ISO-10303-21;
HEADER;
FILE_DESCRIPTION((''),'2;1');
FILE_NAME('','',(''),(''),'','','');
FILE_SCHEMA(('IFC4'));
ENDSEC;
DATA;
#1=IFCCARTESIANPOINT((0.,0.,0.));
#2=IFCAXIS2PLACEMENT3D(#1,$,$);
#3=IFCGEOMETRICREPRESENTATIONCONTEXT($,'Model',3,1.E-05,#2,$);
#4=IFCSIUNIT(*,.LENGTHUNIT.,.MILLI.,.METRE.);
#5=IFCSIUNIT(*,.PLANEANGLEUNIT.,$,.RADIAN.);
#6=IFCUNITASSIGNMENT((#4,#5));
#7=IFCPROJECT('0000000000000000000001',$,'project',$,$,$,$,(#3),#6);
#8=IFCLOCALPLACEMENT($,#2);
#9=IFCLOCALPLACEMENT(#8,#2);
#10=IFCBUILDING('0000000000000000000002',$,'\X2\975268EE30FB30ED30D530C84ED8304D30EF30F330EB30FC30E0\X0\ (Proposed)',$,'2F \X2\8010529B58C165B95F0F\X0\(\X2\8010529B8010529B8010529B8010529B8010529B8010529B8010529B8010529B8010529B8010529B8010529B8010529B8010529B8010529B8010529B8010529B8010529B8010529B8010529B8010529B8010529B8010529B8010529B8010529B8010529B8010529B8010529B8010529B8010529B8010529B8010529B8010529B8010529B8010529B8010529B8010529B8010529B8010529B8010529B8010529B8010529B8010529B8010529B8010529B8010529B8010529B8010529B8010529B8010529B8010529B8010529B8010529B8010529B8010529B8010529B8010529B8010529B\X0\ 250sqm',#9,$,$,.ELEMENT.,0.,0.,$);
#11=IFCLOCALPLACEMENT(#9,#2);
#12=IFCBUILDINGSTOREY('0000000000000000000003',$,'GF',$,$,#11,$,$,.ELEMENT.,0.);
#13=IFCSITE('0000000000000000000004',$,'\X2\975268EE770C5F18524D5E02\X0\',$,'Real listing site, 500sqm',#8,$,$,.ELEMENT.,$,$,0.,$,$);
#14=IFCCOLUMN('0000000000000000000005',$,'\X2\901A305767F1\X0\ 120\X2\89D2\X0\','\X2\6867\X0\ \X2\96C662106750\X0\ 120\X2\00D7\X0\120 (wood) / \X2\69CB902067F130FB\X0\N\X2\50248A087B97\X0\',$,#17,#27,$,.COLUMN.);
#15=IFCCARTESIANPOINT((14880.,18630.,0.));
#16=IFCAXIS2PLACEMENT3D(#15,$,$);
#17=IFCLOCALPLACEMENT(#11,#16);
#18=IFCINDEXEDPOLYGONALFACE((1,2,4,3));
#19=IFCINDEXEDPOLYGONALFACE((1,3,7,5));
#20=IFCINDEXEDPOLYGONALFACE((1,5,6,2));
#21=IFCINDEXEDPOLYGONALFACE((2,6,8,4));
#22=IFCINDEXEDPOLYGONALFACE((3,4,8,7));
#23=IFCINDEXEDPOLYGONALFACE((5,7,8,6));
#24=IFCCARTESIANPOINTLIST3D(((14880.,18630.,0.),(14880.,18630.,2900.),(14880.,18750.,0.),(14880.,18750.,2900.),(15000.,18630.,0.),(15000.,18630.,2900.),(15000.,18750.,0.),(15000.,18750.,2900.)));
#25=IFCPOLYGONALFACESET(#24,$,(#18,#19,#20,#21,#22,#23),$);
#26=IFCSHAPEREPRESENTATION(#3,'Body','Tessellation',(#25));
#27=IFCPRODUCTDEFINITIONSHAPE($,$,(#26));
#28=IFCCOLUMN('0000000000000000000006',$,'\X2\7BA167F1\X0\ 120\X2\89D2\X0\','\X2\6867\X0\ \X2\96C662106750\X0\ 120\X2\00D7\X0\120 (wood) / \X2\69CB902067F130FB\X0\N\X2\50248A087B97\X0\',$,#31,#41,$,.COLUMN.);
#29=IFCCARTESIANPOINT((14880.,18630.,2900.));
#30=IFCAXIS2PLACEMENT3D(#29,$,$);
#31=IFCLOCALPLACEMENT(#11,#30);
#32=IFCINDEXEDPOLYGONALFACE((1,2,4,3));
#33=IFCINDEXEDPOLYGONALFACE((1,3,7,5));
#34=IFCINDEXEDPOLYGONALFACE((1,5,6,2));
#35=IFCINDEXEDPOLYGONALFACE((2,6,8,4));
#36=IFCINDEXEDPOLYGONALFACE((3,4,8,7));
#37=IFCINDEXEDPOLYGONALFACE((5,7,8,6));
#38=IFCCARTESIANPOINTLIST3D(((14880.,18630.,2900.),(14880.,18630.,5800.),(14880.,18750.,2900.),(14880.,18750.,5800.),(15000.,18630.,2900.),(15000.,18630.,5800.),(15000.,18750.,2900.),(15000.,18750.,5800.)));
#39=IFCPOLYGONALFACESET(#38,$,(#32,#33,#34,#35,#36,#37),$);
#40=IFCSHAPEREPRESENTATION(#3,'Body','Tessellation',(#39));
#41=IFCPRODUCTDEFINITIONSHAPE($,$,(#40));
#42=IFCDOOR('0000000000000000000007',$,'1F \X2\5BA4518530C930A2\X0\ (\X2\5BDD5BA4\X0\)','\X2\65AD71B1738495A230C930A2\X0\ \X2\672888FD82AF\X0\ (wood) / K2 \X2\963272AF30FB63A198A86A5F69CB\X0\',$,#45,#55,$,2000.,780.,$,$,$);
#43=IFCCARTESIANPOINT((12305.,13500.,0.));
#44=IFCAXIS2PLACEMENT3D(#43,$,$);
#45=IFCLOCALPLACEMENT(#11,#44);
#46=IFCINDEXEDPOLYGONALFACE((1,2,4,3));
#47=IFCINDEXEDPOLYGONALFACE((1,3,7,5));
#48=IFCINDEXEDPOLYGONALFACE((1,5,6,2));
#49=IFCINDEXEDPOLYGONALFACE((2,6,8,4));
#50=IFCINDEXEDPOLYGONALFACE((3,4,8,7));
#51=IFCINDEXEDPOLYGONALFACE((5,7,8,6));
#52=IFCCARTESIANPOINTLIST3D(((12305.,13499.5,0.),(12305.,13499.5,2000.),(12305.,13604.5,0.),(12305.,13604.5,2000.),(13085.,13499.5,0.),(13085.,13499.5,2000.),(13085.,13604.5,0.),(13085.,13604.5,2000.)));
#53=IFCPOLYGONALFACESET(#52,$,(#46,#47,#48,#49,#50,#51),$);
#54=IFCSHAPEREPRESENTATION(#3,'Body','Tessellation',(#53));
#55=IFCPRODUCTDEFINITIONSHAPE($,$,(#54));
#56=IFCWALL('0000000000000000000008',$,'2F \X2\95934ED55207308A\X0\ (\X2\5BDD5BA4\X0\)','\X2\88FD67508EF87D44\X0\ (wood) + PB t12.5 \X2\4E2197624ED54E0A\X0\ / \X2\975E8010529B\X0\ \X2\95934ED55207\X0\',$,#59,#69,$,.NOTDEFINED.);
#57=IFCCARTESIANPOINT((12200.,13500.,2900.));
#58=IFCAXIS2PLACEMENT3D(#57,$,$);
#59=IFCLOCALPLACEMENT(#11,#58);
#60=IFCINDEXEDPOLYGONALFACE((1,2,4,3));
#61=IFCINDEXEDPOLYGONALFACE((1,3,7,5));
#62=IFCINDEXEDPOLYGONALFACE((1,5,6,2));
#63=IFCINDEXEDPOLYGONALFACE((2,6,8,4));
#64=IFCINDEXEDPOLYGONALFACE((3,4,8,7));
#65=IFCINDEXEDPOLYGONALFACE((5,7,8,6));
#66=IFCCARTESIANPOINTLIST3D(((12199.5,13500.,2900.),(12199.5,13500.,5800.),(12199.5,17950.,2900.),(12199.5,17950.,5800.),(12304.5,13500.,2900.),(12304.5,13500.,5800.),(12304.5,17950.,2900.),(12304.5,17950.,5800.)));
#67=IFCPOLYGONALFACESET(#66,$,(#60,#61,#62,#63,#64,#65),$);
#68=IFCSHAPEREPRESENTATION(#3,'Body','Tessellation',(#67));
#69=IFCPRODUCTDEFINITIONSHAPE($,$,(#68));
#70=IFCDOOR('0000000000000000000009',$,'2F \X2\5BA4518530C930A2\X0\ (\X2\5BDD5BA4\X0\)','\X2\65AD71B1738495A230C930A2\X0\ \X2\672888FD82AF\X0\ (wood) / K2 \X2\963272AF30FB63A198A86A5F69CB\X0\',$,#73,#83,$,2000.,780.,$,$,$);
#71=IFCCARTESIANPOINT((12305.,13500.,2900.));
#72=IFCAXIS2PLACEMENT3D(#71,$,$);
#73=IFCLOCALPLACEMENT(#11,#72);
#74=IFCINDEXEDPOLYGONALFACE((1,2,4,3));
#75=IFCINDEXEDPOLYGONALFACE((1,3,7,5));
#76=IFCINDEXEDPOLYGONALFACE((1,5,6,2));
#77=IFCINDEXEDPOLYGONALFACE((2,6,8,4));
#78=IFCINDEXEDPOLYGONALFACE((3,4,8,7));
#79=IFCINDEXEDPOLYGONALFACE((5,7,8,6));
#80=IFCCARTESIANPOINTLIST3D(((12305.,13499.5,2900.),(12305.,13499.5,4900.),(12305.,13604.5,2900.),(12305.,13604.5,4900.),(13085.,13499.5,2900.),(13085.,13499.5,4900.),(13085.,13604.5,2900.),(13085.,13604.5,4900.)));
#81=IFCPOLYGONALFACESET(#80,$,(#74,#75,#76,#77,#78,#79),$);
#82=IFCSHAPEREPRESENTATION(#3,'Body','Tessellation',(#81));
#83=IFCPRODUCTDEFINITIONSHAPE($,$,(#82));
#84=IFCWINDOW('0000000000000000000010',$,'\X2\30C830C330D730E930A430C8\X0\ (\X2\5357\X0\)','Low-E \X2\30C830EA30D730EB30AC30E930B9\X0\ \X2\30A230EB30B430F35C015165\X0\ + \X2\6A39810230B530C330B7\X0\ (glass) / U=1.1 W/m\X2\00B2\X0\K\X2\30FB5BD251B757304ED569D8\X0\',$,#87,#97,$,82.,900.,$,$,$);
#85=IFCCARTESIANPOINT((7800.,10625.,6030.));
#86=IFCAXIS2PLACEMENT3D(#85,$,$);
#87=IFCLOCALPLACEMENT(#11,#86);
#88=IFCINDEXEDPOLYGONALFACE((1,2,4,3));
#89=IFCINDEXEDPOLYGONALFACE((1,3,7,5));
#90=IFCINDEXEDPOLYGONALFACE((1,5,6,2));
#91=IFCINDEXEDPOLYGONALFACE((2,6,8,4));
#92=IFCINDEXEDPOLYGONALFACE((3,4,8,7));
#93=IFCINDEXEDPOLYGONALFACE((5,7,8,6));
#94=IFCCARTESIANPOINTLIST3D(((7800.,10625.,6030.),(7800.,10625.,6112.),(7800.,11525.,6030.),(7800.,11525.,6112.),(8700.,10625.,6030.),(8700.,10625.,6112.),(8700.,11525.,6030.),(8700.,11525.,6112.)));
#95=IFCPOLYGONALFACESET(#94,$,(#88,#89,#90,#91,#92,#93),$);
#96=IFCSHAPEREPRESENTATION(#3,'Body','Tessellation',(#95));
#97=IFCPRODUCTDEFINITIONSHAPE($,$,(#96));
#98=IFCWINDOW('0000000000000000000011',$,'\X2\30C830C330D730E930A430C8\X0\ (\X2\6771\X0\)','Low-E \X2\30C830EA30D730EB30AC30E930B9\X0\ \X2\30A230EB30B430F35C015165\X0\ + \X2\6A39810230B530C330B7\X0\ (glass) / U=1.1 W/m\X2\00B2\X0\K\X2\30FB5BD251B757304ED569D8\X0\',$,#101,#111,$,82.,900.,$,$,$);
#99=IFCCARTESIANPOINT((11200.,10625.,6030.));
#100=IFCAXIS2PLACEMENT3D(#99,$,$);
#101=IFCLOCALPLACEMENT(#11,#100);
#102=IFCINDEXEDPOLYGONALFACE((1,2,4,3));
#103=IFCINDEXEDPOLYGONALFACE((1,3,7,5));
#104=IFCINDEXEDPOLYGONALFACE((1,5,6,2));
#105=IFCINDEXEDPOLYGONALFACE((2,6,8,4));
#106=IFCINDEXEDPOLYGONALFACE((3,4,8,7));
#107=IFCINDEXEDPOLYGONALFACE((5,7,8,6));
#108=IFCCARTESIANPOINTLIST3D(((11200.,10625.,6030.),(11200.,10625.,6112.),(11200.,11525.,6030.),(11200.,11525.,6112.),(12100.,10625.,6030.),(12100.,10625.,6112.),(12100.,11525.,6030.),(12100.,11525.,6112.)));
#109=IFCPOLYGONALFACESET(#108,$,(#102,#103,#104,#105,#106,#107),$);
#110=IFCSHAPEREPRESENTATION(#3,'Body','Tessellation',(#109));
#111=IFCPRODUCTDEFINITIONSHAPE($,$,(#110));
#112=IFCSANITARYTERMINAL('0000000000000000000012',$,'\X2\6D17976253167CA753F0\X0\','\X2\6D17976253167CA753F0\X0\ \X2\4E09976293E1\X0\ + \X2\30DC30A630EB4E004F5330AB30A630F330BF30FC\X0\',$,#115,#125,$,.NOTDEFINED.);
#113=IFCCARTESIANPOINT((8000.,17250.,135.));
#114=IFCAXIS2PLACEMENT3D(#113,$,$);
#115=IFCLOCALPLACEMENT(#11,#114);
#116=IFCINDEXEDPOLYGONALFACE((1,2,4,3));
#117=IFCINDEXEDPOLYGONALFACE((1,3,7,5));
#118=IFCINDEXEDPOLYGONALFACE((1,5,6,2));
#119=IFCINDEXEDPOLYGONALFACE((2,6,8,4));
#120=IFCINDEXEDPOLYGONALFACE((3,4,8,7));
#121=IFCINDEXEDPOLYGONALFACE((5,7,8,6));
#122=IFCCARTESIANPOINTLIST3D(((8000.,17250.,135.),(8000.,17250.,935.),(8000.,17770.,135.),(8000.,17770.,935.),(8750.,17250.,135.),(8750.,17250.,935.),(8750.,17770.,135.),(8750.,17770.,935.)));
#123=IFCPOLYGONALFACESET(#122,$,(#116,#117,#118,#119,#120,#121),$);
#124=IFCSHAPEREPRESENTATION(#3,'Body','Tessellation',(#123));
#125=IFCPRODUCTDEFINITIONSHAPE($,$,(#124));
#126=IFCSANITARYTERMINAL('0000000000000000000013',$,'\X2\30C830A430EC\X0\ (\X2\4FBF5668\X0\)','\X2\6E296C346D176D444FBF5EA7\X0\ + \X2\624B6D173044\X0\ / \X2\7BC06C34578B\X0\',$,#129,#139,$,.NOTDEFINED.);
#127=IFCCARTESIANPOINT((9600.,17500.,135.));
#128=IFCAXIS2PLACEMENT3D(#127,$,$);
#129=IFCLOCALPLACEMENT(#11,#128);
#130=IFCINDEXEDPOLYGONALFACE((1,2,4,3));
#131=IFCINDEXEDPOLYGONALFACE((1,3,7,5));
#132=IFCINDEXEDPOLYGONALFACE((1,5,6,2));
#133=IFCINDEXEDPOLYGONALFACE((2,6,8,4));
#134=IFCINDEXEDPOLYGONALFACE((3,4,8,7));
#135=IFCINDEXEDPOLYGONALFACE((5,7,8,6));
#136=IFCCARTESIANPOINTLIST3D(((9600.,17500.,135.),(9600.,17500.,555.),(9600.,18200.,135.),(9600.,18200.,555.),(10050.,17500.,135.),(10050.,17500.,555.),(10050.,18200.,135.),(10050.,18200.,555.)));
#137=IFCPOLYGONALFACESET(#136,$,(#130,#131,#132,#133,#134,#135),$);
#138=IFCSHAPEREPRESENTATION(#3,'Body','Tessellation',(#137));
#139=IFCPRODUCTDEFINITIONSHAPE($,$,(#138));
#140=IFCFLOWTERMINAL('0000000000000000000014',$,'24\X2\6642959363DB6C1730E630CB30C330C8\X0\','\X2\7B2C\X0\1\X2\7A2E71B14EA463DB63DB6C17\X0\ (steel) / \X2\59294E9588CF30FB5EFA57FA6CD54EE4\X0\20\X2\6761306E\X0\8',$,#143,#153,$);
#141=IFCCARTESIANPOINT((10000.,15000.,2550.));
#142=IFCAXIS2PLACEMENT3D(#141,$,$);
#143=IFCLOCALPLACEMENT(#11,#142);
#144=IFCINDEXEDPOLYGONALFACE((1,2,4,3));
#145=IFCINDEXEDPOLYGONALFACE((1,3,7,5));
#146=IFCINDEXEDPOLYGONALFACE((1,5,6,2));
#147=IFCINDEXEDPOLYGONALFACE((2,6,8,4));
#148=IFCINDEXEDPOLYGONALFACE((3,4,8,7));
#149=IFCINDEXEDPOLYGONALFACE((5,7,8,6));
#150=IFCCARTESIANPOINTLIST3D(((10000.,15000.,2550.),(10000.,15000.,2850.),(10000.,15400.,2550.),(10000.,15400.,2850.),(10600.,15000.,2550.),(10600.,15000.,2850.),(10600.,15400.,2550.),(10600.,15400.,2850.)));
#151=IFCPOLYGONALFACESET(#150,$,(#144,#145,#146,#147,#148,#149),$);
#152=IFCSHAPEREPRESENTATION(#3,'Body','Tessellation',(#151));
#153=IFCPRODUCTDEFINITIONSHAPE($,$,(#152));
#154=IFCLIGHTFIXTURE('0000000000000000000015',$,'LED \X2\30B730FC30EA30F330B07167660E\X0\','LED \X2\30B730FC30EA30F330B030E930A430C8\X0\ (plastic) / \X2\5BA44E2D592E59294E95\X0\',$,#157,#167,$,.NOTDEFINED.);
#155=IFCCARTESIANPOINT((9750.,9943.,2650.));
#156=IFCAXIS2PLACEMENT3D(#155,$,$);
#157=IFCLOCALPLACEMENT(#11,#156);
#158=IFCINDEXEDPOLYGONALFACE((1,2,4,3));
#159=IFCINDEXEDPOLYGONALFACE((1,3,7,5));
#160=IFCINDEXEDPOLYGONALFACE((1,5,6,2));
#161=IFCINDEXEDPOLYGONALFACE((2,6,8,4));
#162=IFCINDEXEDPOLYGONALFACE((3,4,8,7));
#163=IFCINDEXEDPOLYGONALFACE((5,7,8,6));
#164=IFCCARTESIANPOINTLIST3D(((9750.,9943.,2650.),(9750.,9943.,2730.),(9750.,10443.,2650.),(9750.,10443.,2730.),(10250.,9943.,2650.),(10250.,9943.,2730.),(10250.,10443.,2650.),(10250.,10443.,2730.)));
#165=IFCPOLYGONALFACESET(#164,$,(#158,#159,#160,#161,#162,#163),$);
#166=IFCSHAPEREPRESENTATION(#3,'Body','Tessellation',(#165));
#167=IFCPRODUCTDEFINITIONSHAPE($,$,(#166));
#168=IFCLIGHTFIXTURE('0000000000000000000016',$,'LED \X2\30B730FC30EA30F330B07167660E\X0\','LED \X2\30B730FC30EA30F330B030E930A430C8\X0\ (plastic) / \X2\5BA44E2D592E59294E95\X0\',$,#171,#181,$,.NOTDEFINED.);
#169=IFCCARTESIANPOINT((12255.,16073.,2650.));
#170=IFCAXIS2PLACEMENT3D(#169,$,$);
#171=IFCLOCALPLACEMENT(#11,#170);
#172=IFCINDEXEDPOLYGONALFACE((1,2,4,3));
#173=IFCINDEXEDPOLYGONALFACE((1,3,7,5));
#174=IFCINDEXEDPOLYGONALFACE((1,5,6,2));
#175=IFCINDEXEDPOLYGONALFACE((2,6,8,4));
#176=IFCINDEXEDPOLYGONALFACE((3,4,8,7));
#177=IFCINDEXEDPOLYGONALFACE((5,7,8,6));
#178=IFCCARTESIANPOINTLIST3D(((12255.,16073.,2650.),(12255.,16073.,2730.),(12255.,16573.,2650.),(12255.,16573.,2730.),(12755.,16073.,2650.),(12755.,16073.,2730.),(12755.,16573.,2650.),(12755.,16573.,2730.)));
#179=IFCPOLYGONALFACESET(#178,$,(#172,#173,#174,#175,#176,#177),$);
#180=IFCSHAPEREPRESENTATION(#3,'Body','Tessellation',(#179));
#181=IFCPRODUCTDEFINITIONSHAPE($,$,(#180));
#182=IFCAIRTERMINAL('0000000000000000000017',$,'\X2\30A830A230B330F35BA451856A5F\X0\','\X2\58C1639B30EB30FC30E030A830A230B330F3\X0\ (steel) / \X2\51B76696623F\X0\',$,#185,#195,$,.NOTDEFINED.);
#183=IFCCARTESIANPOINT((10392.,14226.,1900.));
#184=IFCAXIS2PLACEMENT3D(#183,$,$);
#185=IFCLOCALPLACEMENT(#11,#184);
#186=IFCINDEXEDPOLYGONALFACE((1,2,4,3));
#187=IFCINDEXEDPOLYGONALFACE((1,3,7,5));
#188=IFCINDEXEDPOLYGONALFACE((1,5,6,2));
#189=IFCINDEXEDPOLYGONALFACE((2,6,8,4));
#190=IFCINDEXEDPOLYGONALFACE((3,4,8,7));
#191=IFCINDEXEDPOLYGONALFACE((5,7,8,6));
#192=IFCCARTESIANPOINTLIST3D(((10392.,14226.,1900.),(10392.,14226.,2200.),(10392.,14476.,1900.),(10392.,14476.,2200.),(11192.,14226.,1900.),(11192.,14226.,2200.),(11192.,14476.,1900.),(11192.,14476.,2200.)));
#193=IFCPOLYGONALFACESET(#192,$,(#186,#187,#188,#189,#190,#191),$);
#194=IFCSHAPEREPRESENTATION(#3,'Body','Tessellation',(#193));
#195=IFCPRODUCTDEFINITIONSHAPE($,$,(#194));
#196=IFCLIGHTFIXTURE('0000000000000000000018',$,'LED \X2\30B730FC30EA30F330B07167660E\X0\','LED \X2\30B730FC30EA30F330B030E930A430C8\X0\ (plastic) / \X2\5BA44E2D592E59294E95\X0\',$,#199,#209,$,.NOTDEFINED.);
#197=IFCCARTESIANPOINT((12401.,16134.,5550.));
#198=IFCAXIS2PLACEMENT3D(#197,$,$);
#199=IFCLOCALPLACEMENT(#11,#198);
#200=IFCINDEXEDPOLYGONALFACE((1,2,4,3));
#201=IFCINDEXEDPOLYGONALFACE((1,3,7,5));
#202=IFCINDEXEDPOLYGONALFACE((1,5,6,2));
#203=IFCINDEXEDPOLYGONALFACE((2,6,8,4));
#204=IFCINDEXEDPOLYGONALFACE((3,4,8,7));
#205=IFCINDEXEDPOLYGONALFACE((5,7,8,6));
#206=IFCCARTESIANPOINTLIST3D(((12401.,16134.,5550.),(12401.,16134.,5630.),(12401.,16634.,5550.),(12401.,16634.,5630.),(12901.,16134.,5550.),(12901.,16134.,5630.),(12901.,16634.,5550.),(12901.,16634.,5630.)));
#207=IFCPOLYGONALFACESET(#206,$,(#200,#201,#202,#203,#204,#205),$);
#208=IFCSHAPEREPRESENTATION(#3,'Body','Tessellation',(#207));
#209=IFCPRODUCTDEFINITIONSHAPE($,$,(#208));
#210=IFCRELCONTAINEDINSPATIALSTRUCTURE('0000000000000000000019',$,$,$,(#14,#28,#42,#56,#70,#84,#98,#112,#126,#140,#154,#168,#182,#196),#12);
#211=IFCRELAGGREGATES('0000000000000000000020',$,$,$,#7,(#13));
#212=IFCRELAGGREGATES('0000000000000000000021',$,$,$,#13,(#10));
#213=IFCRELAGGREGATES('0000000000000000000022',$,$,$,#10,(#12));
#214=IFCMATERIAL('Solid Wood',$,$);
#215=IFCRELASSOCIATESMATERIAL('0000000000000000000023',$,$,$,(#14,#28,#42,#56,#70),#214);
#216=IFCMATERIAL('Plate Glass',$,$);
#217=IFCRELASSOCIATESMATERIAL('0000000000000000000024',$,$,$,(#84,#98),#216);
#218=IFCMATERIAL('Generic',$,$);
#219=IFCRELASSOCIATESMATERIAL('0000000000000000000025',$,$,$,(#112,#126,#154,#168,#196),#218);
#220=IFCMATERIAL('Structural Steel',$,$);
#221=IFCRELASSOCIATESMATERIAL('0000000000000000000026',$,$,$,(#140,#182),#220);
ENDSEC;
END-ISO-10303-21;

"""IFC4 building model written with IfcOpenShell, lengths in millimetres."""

from ifc_helpers import new_model, si_unit, frame, frame_2d, origin, place, context, project, spatial, rectangle, extrude, material, element, save


model = new_model("IFC4")

# Units and contexts
model_context = context("Model", 3, precision=1e-05, world=origin())
ifc_project = project(units=[si_unit("LENGTHUNIT", "METRE", prefix="MILLI"), si_unit("PLANEANGLEUNIT", "RADIAN")], contexts=[model_context])

# Site, building, storey
site_placement = place(None, origin())
site = spatial("IfcSite", under=ifc_project, at=site_placement, Name="青森県弘前市", ObjectType="Real listing site, 500sqm", CompositionType="ELEMENT", RefElevation=0.0)
building_placement = place(site_placement, origin())
building = spatial("IfcBuilding", under=site, at=building_placement, Name="青森・ロフト付きワンルーム (Proposed)", ObjectType="2F 耐力壁方式(耐力耐力耐力耐力耐力耐力耐力耐力耐力耐力耐力耐力耐力耐力耐力耐力耐力耐力耐力耐力耐力耐力耐力耐力耐力耐力耐力耐力耐力耐力耐力耐力耐力耐力耐力耐力耐力耐力耐力耐力耐力耐力耐力耐力耐力耐力耐力耐力耐力耐力耐力耐力耐力耐力耐力耐力耐力 250sqm", CompositionType="ELEMENT", ElevationOfRefHeight=0.0, ElevationOfTerrain=0.0)
storey_placement = place(building_placement, origin())
storey = spatial("IfcBuildingStorey", under=building, at=storey_placement, Name="GF", CompositionType="ELEMENT", Elevation=0.0)

# Columns
ifc_material_1 = material(Name="Solid Wood")
column_1_placement = place(storey_placement, frame((14880.0, 18630.0, 0.0)))
element("IfcColumn", 1, at=column_1_placement, inside=storey, material=ifc_material_1, Name="通し柱 120角", Description="桧 集成材 120×120 (wood) / 構造柱・N値計算", PredefinedType="COLUMN", context=model_context, shape_type="SweptSolid", body=[
    extrude(rectangle(XDim=120.0, YDim=120.0, at=frame_2d((60.0, 60.0))), frame((14880.0, 18630.0, 0.0)), (0.0, 0.0, 1.0), 2900.0),
])
column_2_placement = place(storey_placement, frame((14880.0, 18630.0, 2900.0)))
element("IfcColumn", 2, at=column_2_placement, inside=storey, material=ifc_material_1, Name="管柱 120角", Description="桧 集成材 120×120 (wood) / 構造柱・N値計算", PredefinedType="COLUMN", context=model_context, shape_type="SweptSolid", body=[
    extrude(rectangle(XDim=120.0, YDim=120.0, at=frame_2d((60.0, 60.0))), frame((14880.0, 18630.0, 2900.0)), (0.0, 0.0, 1.0), 2900.0),
])

# Door
door_1_placement = place(storey_placement, frame((12305.0, 13500.0, 0.0)))
element("IfcDoor", 3, at=door_1_placement, inside=storey, material=ifc_material_1, Name="1F 室内ドア (寝室)", Description="断熱玄関ドア 木製芯 (wood) / K2 防犯・採風機構", OverallHeight=2000.0, OverallWidth=780.0, context=model_context, shape_type="SweptSolid", body=[
    extrude(rectangle(XDim=780.0, YDim=105.0, at=frame_2d((390.0, 52.0))), frame((12305.0, 13500.0, 0.0)), (0.0, 0.0, 1.0), 2000.0),
])

# Wall
wall_1_placement = place(storey_placement, frame((12200.0, 13500.0, 2900.0)))
element("IfcWall", 4, at=wall_1_placement, inside=storey, material=ifc_material_1, Name="2F 間仕切り (寝室)", Description="製材軸組 (wood) + PB t12.5 両面仕上 / 非耐力 間仕切", PredefinedType="NOTDEFINED", context=model_context, shape_type="SweptSolid", body=[
    extrude(rectangle(XDim=105.0, YDim=4450.0, at=frame_2d((52.0, 2225.0))), frame((12200.0, 13500.0, 2900.0)), (0.0, 0.0, 1.0), 2900.0),
])

# Door
door_2_placement = place(storey_placement, frame((12305.0, 13500.0, 2900.0)))
element("IfcDoor", 5, at=door_2_placement, inside=storey, material=ifc_material_1, Name="2F 室内ドア (寝室)", Description="断熱玄関ドア 木製芯 (wood) / K2 防犯・採風機構", OverallHeight=2000.0, OverallWidth=780.0, context=model_context, shape_type="SweptSolid", body=[
    extrude(rectangle(XDim=780.0, YDim=105.0, at=frame_2d((390.0, 52.0))), frame((12305.0, 13500.0, 2900.0)), (0.0, 0.0, 1.0), 2000.0),
])

# Windows
ifc_material_2 = material(Name="Plate Glass")
window_1_placement = place(storey_placement, frame((7800.0, 10625.0, 6030.0)))
element("IfcWindow", 6, at=window_1_placement, inside=storey, material=ifc_material_2, Name="トップライト (南)", Description="Low-E トリプルガラス アルゴン封入 + 樹脂サッシ (glass) / U=1.1 W/m²K・寒冷地仕様", OverallHeight=82.0, OverallWidth=900.0, context=model_context, shape_type="SweptSolid", body=[
    extrude(rectangle(XDim=900.0, YDim=900.0, at=frame_2d((450.0, 450.0))), frame((7800.0, 10625.0, 6030.0)), (0.0, 0.0, 1.0), 82.0),
])
window_2_placement = place(storey_placement, frame((11200.0, 10625.0, 6030.0)))
element("IfcWindow", 7, at=window_2_placement, inside=storey, material=ifc_material_2, Name="トップライト (東)", Description="Low-E トリプルガラス アルゴン封入 + 樹脂サッシ (glass) / U=1.1 W/m²K・寒冷地仕様", OverallHeight=82.0, OverallWidth=900.0, context=model_context, shape_type="SweptSolid", body=[
    extrude(rectangle(XDim=900.0, YDim=900.0, at=frame_2d((450.0, 450.0))), frame((11200.0, 10625.0, 6030.0)), (0.0, 0.0, 1.0), 82.0),
])

# Sanitary terminals
ifc_material_3 = material(Name="Generic")
sanitary_terminal_1_placement = place(storey_placement, frame((8000.0, 17250.0, 135.0)))
element("IfcSanitaryTerminal", 8, at=sanitary_terminal_1_placement, inside=storey, material=ifc_material_3, Name="洗面化粧台", Description="洗面化粧台 三面鏡 + ボウル一体カウンター", PredefinedType="NOTDEFINED", context=model_context, shape_type="SweptSolid", body=[
    extrude(rectangle(XDim=750.0, YDim=520.0, at=frame_2d((375.0, 260.0))), frame((8000.0, 17250.0, 135.0)), (0.0, 0.0, 1.0), 800.0),
])
sanitary_terminal_2_placement = place(storey_placement, frame((9600.0, 17500.0, 135.0)))
element("IfcSanitaryTerminal", 9, at=sanitary_terminal_2_placement, inside=storey, material=ifc_material_3, Name="トイレ (便器)", Description="温水洗浄便座 + 手洗い / 節水型", PredefinedType="NOTDEFINED", context=model_context, shape_type="SweptSolid", body=[
    extrude(rectangle(XDim=450.0, YDim=700.0, at=frame_2d((225.0, 350.0))), frame((9600.0, 17500.0, 135.0)), (0.0, 0.0, 1.0), 420.0),
])

# Flow terminal
ifc_material_4 = material(Name="Structural Steel")
flow_terminal_placement = place(storey_placement, frame((10000.0, 15000.0, 2550.0)))
element("IfcFlowTerminal", 10, at=flow_terminal_placement, inside=storey, material=ifc_material_4, Name="24時間換気ユニット", Description="第1種熱交換換気 (steel) / 天井裏・建基法令20条の8", context=model_context, shape_type="SweptSolid", body=[
    extrude(rectangle(XDim=600.0, YDim=400.0, at=frame_2d((300.0, 200.0))), frame((10000.0, 15000.0, 2550.0)), (0.0, 0.0, 1.0), 300.0),
])

# Light fixtures
light_fixture_1_placement = place(storey_placement, frame((9750.0, 9943.0, 2650.0)))
element("IfcLightFixture", 11, at=light_fixture_1_placement, inside=storey, material=ifc_material_3, Name="LED シーリング照明", Description="LED シーリングライト (plastic) / 室中央天井", PredefinedType="NOTDEFINED", context=model_context, shape_type="SweptSolid", body=[
    extrude(rectangle(XDim=500.0, YDim=500.0, at=frame_2d((250.0, 250.0))), frame((9750.0, 9943.0, 2650.0)), (0.0, 0.0, 1.0), 80.0),
])
light_fixture_2_placement = place(storey_placement, frame((12255.0, 16073.0, 2650.0)))
element("IfcLightFixture", 12, at=light_fixture_2_placement, inside=storey, material=ifc_material_3, Name="LED シーリング照明", Description="LED シーリングライト (plastic) / 室中央天井", PredefinedType="NOTDEFINED", context=model_context, shape_type="SweptSolid", body=[
    extrude(rectangle(XDim=500.0, YDim=500.0, at=frame_2d((250.0, 250.0))), frame((12255.0, 16073.0, 2650.0)), (0.0, 0.0, 1.0), 80.0),
])

# Air terminal
air_terminal_placement = place(storey_placement, frame((10392.0, 14226.0, 1900.0)))
element("IfcAirTerminal", 13, at=air_terminal_placement, inside=storey, material=ifc_material_4, Name="エアコン室内機", Description="壁掛ルームエアコン (steel) / 冷暖房", PredefinedType="NOTDEFINED", context=model_context, shape_type="SweptSolid", body=[
    extrude(rectangle(XDim=800.0, YDim=250.0, at=frame_2d((400.0, 125.0))), frame((10392.0, 14226.0, 1900.0)), (0.0, 0.0, 1.0), 300.0),
])

# Light fixture
light_fixture_3_placement = place(storey_placement, frame((12401.0, 16134.0, 5550.0)))
element("IfcLightFixture", 14, at=light_fixture_3_placement, inside=storey, material=ifc_material_3, Name="LED シーリング照明", Description="LED シーリングライト (plastic) / 室中央天井", PredefinedType="NOTDEFINED", context=model_context, shape_type="SweptSolid", body=[
    extrude(rectangle(XDim=500.0, YDim=500.0, at=frame_2d((250.0, 250.0))), frame((12401.0, 16134.0, 5550.0)), (0.0, 0.0, 1.0), 80.0),
])

save(model, "model.ifc")
